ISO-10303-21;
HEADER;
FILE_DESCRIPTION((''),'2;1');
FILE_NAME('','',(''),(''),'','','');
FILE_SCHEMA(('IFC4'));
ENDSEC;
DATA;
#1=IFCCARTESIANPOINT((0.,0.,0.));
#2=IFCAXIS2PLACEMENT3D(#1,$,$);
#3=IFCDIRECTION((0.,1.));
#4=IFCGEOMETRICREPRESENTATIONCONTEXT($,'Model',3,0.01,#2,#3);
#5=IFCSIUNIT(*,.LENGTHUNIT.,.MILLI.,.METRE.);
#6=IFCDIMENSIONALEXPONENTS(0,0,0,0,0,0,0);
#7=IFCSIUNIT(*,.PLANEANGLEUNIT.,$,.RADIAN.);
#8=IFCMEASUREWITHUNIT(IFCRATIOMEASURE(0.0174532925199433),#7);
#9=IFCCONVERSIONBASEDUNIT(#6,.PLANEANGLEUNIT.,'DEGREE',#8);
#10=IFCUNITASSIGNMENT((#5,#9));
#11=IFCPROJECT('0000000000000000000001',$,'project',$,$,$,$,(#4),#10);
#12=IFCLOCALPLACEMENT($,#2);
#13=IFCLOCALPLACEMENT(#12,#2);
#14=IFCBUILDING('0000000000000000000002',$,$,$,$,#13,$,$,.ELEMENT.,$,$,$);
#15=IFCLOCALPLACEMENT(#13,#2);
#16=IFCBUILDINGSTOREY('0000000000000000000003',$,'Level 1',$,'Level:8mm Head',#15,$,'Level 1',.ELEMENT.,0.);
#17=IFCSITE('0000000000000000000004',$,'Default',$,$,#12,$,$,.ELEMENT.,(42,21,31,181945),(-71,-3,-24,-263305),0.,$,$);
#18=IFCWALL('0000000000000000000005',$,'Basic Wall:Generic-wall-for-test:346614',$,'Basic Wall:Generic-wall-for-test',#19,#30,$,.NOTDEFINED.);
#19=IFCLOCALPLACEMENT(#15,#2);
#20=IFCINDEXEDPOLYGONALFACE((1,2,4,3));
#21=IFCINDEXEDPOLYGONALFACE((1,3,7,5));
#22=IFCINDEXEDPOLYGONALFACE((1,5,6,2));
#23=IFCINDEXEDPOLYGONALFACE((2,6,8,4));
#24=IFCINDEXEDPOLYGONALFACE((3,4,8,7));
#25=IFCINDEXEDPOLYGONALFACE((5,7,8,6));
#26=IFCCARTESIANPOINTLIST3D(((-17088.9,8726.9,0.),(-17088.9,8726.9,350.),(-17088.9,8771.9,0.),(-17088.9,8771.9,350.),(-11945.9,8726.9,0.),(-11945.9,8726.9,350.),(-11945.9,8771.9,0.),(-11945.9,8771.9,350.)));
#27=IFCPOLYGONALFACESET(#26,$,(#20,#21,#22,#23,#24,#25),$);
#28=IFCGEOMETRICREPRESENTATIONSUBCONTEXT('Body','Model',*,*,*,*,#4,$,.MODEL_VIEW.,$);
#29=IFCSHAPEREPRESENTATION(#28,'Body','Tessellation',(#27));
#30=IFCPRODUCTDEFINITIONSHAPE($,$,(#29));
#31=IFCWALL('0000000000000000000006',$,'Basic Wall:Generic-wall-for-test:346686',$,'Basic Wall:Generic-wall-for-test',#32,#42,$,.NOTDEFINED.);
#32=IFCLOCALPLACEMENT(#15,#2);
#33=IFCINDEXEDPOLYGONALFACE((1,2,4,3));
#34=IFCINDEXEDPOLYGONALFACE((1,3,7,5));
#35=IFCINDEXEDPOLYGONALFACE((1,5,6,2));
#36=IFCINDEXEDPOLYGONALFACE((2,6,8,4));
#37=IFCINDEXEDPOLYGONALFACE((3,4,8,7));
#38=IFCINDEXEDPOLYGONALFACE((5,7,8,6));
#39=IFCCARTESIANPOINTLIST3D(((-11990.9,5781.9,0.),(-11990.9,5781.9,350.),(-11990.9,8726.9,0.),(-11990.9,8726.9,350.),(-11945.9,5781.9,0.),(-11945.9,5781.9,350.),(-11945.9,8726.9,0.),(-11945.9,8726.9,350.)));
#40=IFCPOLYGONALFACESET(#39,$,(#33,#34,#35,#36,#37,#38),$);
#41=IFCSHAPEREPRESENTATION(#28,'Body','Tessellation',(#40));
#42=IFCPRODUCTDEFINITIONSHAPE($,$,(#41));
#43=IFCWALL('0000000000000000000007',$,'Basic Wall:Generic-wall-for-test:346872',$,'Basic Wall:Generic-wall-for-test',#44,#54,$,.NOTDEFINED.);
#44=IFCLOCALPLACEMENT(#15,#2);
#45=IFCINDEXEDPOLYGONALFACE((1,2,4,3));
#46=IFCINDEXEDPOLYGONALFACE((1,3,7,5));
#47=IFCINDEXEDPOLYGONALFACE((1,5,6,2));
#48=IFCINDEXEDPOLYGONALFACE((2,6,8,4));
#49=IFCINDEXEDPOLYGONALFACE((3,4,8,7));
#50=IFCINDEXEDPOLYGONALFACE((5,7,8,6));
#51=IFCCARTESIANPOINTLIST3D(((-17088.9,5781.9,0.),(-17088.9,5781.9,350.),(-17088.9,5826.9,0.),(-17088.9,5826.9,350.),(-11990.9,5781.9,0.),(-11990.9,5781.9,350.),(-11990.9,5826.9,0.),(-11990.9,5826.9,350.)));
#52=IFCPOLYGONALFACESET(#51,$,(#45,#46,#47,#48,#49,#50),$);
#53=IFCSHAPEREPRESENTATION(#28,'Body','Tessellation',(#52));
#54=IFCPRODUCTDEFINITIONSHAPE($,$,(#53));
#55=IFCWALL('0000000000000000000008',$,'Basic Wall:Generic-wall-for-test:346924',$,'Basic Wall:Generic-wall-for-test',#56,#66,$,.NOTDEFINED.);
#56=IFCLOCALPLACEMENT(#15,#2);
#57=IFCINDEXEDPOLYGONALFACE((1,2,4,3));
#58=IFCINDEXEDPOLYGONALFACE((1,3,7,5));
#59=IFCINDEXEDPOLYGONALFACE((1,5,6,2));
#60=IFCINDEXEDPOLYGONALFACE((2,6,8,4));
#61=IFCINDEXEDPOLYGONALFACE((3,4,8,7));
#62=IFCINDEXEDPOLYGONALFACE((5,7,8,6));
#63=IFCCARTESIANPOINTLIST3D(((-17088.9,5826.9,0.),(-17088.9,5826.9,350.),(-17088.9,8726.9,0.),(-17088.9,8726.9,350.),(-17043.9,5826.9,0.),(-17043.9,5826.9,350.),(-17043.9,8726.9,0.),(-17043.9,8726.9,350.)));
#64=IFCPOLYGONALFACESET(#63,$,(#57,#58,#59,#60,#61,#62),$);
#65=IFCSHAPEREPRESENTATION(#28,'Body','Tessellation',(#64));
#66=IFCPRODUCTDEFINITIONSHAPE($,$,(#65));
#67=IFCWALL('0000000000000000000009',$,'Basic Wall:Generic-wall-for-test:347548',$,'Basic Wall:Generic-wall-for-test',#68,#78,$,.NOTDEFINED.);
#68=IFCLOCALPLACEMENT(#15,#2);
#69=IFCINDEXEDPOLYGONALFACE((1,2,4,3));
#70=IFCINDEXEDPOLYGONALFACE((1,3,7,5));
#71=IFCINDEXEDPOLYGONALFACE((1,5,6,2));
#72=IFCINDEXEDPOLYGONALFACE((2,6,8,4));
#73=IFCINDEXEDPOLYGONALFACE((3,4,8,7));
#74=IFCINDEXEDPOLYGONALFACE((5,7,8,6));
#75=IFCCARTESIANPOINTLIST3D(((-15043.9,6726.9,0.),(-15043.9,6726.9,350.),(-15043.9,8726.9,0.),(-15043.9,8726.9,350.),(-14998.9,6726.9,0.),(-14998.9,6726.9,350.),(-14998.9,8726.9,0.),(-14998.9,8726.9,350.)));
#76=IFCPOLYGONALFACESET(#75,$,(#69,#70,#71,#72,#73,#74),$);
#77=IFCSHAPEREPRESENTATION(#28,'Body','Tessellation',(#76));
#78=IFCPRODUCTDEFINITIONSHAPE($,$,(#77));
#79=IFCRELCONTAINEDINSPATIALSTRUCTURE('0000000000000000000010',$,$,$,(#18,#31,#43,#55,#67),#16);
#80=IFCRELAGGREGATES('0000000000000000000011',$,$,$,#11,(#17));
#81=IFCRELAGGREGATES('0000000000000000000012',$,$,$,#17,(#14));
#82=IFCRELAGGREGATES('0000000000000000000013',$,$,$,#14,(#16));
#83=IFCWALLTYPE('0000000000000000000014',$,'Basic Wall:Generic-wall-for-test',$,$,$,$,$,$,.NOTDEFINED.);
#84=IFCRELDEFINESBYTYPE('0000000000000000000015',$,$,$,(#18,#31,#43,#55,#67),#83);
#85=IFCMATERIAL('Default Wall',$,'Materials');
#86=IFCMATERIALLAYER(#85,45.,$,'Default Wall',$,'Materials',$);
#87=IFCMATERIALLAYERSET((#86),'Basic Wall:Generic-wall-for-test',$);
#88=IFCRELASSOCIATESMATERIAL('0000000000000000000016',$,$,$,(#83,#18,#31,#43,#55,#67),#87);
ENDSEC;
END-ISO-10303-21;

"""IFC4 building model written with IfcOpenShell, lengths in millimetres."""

from ifc_helpers import new_model, entity, si_unit, converted_unit, direction, frame, origin, place, context, subcontext, project, spatial, indexed_curve, outline, extrude, material, layer, layer_set, type_object, element, save


model = new_model("IFC4")

# Units and contexts
model_context = context("Model", 3, precision=0.01, world=origin(), true_north=direction((0.0, 1.0)))
body_context = subcontext(model_context, "Body", "Model", "MODEL_VIEW")
ifc_project = project(units=[si_unit("LENGTHUNIT", "METRE", prefix="MILLI"), converted_unit("PLANEANGLEUNIT", "DEGREE", entity("IfcRatioMeasure", 0.0174532925199433), si_unit("PLANEANGLEUNIT", "RADIAN"), dimensions=[0, 0, 0, 0, 0, 0, 0])], contexts=[model_context])

# Site, building, storey
site_placement = place(None, origin())
site = spatial("IfcSite", under=ifc_project, at=site_placement, Name="Default", CompositionType="ELEMENT", RefLatitude=(42, 21, 31, 181945), RefLongitude=(-71, -3, -24, -263305), RefElevation=0.0)
building_placement = place(site_placement, origin())
building = spatial("IfcBuilding", under=site, at=building_placement, CompositionType="ELEMENT")
storey_placement = place(building_placement, origin())
storey = spatial("IfcBuildingStorey", under=building, at=storey_placement, Name="Level 1", ObjectType="Level:8mm Head", LongName="Level 1", CompositionType="ELEMENT", Elevation=0.0)

# Walls
ifc_material = material(Name="Default Wall", Category="Materials")
ifc_layer = layer(ifc_material, 45.0, Name="Default Wall", Category="Materials")
ifc_layer_set = layer_set([ifc_layer], Name="Basic Wall:Generic-wall-for-test")
wall_type = type_object("IfcWallType", Name="Basic Wall:Generic-wall-for-test", PredefinedType="NOTDEFINED", material=ifc_layer_set)
wall_1_placement = place(storey_placement, frame((-17088.9, 8749.4, 0.0)))
element("IfcWall", 1, at=wall_1_placement, inside=storey, type_object=wall_type, material=ifc_layer_set, Name="Basic Wall:Generic-wall-for-test:346614", ObjectType="Basic Wall:Generic-wall-for-test", PredefinedType="NOTDEFINED", context=body_context, shape_type="SweptSolid", body=[
    extrude(outline(indexed_curve([(5143.0, 22.5), (0.0, 22.5), (0.0, -22.5), (5143.0, -22.5), (5143.0, 22.5)], self_intersect=False)), origin(), (0.0, 0.0, 1.0), 350.0),
])
wall_2_placement = place(storey_placement, frame((-11968.4, 8726.9, 0.0), z_axis=(0.0, 0.0, 1.0), x_axis=(0.0, -1.0, 0.0)))
element("IfcWall", 2, at=wall_2_placement, inside=storey, type_object=wall_type, material=ifc_layer_set, Name="Basic Wall:Generic-wall-for-test:346686", ObjectType="Basic Wall:Generic-wall-for-test", PredefinedType="NOTDEFINED", context=body_context, shape_type="SweptSolid", body=[
    extrude(outline(indexed_curve([(2945.0, 22.5), (0.0, 22.5), (0.0, -22.5), (2945.0, -22.5), (2945.0, 22.5)], self_intersect=False)), origin(), (0.0, 0.0, 1.0), 350.0),
])
wall_3_placement = place(storey_placement, frame((-11990.9, 5804.4, 0.0), z_axis=(0.0, 0.0, 1.0), x_axis=(-1.0, 0.0, 0.0)))
element("IfcWall", 3, at=wall_3_placement, inside=storey, type_object=wall_type, material=ifc_layer_set, Name="Basic Wall:Generic-wall-for-test:346872", ObjectType="Basic Wall:Generic-wall-for-test", PredefinedType="NOTDEFINED", context=body_context, shape_type="SweptSolid", body=[
    extrude(outline(indexed_curve([(5098.0, 22.5), (0.0, 22.5), (0.0, -22.5), (5098.0, -22.5), (5098.0, 22.5)], self_intersect=False)), origin(), (0.0, 0.0, 1.0), 350.0),
])
wall_4_placement = place(storey_placement, frame((-17066.4, 5826.9, 0.0), z_axis=(0.0, 0.0, 1.0), x_axis=(0.0, 1.0, 0.0)))
element("IfcWall", 4, at=wall_4_placement, inside=storey, type_object=wall_type, material=ifc_layer_set, Name="Basic Wall:Generic-wall-for-test:346924", ObjectType="Basic Wall:Generic-wall-for-test", PredefinedType="NOTDEFINED", context=body_context, shape_type="SweptSolid", body=[
    extrude(outline(indexed_curve([(2900.0, 22.5), (0.0, 22.5), (0.0, -22.5), (2900.0, -22.5), (2900.0, 22.5)], self_intersect=False)), origin(), (0.0, 0.0, 1.0), 350.0),
])
wall_5_placement = place(storey_placement, frame((-15021.4, 8726.9, 0.0), z_axis=(0.0, 0.0, 1.0), x_axis=(0.0, -1.0, 0.0)))
element("IfcWall", 5, at=wall_5_placement, inside=storey, type_object=wall_type, material=ifc_layer_set, Name="Basic Wall:Generic-wall-for-test:347548", ObjectType="Basic Wall:Generic-wall-for-test", PredefinedType="NOTDEFINED", context=body_context, shape_type="SweptSolid", body=[
    extrude(outline(indexed_curve([(2000.0, 22.5), (0.0, 22.5), (0.0, -22.5), (2000.0, -22.5), (2000.0, 22.5)], self_intersect=False)), origin(), (0.0, 0.0, 1.0), 350.0),
])

save(model, "model.ifc")
